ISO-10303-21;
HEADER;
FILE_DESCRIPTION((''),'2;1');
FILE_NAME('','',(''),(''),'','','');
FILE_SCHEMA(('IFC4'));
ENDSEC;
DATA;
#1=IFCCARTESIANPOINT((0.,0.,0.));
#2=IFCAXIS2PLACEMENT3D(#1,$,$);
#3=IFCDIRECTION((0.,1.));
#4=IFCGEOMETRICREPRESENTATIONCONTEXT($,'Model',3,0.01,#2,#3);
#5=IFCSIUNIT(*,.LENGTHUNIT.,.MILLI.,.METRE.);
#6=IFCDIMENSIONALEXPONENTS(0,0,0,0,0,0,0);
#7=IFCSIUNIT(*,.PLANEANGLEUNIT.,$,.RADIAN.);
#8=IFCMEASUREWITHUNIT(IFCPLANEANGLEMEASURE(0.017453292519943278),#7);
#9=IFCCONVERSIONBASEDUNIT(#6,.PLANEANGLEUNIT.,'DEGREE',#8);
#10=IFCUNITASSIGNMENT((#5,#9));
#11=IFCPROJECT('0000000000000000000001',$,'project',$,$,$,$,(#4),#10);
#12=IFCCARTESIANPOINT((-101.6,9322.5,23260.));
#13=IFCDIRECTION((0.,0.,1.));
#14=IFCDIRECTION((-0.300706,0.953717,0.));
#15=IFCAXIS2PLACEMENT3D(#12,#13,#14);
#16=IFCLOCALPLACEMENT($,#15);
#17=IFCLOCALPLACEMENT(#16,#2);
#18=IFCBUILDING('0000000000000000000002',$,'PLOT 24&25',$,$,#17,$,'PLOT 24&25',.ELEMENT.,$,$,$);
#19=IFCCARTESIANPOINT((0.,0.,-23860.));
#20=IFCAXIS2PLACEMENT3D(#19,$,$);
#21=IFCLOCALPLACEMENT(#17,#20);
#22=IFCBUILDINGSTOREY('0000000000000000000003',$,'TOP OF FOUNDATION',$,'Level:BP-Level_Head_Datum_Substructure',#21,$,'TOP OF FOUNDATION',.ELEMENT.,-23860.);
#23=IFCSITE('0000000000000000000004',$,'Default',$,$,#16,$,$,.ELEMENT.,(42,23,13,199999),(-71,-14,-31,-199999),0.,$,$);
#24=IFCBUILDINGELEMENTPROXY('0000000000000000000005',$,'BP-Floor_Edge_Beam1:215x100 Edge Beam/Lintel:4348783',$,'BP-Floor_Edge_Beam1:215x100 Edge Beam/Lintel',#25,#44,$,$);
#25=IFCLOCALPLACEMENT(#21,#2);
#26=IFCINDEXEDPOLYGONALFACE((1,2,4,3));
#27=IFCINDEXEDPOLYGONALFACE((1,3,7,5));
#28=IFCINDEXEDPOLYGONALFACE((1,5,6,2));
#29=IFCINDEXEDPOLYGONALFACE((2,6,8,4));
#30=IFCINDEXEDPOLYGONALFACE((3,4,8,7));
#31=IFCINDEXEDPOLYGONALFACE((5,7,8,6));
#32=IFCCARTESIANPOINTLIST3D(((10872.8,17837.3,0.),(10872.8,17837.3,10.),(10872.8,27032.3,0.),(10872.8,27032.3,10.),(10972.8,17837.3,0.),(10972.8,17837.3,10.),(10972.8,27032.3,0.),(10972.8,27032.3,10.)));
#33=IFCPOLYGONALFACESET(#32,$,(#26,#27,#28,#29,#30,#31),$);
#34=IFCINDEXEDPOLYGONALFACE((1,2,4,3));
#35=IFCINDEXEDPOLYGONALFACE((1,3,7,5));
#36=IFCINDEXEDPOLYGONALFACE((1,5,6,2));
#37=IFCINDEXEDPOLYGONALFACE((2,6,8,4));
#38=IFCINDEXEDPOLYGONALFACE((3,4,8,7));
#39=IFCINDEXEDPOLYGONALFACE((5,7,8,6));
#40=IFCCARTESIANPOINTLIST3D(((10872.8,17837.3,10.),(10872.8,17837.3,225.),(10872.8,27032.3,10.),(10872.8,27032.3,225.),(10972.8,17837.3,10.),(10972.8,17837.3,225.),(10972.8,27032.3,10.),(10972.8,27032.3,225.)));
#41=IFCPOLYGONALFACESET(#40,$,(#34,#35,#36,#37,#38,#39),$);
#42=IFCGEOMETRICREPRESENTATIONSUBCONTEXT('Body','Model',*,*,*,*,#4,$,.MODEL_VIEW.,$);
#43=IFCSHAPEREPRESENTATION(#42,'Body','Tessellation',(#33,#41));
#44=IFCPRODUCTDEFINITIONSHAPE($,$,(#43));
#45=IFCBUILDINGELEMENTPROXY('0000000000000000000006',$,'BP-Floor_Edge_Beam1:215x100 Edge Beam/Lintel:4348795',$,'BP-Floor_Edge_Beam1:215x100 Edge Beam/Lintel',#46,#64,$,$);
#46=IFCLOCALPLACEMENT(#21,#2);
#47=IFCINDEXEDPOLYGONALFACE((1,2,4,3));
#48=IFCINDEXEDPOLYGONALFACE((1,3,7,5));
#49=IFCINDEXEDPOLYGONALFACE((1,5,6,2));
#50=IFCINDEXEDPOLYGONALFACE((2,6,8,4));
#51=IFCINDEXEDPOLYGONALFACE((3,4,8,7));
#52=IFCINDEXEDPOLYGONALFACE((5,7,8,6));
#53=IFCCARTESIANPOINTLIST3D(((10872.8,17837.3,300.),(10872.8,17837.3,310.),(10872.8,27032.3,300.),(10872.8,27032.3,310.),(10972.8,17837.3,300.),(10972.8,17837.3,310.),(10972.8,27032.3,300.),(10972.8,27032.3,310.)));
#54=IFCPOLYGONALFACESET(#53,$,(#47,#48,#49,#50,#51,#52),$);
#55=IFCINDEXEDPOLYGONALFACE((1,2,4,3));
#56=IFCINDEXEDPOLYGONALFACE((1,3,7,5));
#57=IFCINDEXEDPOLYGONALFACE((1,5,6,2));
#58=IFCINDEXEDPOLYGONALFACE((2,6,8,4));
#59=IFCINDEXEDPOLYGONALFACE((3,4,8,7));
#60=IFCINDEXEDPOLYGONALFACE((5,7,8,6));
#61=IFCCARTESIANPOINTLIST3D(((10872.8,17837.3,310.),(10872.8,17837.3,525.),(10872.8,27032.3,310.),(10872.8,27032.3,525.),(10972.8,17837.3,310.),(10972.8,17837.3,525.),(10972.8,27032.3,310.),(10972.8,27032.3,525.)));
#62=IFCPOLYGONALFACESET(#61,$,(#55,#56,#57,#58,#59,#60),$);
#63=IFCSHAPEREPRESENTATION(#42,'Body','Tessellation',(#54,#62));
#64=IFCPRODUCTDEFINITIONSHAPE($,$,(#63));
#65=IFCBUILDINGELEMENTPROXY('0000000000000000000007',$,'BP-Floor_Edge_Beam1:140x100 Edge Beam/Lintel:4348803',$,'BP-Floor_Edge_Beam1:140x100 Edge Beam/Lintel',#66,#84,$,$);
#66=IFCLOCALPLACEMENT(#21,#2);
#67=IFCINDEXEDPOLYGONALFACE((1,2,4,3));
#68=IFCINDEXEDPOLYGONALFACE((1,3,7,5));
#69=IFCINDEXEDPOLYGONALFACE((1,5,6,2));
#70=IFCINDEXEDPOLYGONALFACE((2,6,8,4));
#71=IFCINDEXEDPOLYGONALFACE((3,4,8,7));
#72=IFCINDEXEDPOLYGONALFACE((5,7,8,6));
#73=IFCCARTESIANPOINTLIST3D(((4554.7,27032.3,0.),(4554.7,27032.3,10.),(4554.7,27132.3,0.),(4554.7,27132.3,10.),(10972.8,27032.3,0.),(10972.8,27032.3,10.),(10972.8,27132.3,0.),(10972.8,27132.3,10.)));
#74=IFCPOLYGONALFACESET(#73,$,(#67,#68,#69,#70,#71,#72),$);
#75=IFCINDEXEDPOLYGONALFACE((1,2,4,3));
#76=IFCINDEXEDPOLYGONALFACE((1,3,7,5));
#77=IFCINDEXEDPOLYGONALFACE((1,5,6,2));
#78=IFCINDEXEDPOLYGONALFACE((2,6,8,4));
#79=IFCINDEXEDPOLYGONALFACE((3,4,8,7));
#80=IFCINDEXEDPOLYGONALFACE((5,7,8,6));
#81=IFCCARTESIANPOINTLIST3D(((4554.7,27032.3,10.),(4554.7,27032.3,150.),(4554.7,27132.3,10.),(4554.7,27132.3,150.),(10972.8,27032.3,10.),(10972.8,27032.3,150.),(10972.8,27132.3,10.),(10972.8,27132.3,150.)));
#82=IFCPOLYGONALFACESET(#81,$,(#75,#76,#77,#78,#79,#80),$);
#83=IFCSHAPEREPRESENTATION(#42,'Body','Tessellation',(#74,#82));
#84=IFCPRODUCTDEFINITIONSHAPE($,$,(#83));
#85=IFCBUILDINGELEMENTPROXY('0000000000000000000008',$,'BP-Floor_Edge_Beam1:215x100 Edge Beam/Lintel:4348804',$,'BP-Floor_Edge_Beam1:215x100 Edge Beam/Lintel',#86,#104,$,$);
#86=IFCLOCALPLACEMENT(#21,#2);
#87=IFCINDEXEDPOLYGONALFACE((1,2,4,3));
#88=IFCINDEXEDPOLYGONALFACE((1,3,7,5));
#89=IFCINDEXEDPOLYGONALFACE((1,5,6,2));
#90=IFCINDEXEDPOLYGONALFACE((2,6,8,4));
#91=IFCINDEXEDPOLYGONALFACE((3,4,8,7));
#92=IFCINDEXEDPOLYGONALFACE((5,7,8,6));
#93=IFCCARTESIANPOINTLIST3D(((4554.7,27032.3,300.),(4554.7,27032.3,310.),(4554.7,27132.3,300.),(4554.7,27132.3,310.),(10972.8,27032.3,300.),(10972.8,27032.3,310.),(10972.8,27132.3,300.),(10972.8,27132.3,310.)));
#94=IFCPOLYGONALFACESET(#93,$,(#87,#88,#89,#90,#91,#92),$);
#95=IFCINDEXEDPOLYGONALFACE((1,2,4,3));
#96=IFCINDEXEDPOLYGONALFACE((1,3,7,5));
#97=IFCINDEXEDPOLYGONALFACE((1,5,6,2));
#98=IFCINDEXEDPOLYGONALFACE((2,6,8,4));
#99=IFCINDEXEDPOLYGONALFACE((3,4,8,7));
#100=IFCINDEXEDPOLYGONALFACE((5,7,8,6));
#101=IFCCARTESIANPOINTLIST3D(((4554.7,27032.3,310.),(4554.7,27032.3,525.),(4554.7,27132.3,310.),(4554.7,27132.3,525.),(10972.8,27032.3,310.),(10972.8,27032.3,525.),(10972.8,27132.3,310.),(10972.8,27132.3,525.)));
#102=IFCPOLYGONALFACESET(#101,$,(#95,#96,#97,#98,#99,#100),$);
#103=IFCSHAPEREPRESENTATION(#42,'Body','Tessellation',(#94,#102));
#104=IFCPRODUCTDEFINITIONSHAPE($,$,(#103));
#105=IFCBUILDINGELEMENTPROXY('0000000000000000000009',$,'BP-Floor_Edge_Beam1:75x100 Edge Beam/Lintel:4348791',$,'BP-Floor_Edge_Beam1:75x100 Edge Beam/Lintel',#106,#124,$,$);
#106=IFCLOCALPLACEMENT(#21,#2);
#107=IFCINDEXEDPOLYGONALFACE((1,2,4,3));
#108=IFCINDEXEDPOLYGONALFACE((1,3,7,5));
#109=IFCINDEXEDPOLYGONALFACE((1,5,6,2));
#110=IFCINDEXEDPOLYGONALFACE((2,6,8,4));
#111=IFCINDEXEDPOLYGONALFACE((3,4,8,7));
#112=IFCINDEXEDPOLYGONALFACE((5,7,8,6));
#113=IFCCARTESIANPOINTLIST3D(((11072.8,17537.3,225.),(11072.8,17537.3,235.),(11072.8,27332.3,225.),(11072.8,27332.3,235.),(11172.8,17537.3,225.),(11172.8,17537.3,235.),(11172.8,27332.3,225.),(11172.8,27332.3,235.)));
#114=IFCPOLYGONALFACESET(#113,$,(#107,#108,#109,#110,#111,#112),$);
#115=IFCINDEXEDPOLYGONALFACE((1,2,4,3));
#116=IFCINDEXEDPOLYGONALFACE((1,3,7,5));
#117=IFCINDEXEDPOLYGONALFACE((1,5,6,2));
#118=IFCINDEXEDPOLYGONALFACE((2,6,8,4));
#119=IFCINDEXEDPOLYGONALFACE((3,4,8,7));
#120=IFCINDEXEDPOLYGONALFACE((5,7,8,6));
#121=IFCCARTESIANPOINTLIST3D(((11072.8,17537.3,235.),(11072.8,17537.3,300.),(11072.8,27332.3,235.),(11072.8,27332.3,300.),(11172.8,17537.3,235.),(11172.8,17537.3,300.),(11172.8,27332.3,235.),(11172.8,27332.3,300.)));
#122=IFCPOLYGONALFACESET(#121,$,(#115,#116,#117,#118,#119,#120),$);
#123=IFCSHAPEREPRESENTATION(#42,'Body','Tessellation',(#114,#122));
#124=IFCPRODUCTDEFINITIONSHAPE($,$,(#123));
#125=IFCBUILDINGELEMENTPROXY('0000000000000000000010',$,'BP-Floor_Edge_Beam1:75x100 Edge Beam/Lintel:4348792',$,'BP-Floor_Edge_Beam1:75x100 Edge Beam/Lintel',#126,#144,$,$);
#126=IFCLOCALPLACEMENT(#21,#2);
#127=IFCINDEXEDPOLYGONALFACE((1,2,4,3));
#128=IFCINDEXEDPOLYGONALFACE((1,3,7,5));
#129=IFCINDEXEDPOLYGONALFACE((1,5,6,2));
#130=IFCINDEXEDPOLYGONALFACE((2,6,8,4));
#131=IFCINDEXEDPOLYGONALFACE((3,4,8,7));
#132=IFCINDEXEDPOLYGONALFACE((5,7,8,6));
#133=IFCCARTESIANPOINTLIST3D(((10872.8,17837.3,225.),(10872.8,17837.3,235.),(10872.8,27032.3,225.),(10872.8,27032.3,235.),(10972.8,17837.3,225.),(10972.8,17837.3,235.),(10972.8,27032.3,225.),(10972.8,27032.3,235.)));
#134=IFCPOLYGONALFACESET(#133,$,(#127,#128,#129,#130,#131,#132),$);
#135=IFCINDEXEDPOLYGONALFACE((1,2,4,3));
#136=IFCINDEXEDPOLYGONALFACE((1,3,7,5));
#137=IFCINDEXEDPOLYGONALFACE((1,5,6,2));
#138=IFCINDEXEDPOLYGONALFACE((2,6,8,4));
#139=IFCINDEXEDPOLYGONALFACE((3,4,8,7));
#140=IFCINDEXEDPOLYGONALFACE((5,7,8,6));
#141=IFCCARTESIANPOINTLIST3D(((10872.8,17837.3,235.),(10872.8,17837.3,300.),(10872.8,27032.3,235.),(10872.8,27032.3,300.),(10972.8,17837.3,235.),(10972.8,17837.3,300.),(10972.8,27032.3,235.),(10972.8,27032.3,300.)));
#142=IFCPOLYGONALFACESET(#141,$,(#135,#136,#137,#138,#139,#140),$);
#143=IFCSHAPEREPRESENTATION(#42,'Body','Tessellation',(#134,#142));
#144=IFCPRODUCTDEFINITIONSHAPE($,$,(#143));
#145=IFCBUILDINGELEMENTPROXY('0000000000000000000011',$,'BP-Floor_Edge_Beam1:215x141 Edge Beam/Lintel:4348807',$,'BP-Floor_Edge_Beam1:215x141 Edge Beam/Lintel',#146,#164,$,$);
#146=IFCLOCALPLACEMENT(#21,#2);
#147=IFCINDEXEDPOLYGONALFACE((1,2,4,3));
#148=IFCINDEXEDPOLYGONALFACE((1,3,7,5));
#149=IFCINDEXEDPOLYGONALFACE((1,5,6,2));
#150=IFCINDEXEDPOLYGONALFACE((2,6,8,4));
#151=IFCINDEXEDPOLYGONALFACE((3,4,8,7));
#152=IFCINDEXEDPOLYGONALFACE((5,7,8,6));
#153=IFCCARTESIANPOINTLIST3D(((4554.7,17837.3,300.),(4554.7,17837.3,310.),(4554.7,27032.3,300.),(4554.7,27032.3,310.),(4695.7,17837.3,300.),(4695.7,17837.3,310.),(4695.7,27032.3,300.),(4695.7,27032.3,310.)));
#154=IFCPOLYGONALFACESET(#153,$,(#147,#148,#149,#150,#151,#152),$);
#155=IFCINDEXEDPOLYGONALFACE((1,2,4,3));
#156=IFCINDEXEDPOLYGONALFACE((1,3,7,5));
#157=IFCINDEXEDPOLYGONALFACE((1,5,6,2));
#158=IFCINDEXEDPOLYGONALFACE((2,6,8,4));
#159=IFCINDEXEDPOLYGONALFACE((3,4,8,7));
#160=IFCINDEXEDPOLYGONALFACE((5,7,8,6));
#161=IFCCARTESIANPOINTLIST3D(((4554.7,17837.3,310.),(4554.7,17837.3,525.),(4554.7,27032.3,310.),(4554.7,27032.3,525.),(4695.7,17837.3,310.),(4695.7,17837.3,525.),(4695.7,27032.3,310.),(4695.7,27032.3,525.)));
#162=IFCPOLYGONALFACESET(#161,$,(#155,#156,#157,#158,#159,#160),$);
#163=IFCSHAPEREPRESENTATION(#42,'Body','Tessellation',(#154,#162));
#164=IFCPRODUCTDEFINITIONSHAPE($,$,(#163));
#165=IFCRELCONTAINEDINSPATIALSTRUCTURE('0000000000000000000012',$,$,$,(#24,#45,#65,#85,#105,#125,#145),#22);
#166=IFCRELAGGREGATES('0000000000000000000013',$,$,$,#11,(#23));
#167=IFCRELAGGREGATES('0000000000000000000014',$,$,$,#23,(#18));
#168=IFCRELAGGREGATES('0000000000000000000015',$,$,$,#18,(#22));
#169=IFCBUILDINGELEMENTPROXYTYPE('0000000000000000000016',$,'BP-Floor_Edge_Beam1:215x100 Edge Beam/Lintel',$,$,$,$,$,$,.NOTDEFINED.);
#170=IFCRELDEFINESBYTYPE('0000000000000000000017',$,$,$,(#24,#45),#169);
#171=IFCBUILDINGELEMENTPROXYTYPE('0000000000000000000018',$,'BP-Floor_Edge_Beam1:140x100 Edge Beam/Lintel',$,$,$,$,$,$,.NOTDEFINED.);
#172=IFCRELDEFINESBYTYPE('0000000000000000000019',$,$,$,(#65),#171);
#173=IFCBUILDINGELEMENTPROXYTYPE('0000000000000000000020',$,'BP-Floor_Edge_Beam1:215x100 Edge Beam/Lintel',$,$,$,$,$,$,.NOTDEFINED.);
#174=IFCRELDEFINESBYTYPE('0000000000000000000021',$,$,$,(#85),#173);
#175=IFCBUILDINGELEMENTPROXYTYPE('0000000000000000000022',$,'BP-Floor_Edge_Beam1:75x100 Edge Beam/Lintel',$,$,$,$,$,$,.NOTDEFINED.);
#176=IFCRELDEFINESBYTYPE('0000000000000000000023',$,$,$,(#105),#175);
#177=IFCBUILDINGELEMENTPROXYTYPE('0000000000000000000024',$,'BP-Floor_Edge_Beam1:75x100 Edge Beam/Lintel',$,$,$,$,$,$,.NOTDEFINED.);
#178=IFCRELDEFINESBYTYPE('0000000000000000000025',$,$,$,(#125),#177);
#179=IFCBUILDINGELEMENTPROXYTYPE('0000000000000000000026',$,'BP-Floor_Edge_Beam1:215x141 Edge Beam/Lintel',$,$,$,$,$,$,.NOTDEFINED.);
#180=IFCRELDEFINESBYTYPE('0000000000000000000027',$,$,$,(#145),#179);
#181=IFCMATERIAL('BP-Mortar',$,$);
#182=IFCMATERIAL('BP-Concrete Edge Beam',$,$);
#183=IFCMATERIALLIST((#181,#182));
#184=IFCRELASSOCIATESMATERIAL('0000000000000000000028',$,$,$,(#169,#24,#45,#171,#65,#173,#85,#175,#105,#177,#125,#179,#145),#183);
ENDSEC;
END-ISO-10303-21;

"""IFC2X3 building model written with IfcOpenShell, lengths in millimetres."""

from ifc_helpers import new_model, entity, si_unit, converted_unit, direction, frame, frame_2d, origin, origin_2d_with_axis, place, context, subcontext, project, spatial, rectangle, extrude, source, transform, mapped, material, material_list, type_object, type_shapes, element, save


model = new_model("IFC2X3")

# Units and contexts
model_context = context("Model", 3, precision=0.01, world=origin(), true_north=direction((0.0, 1.0)))
body_context = subcontext(model_context, "Body", "Model", "MODEL_VIEW")
ifc_project = project(units=[si_unit("LENGTHUNIT", "METRE", prefix="MILLI"), converted_unit("PLANEANGLEUNIT", "DEGREE", entity("IfcPlaneAngleMeasure", 0.017453292519943278), si_unit("PLANEANGLEUNIT", "RADIAN"), dimensions=[0, 0, 0, 0, 0, 0, 0])], contexts=[model_context])

# Site, building, storey
site_placement = place(None, frame((-101.6, 9322.5, 23260.0), z_axis=(0.0, 0.0, 1.0), x_axis=(-0.300706, 0.953717, 0.0)))
site = spatial("IfcSite", under=ifc_project, at=site_placement, Name="Default", CompositionType="ELEMENT", RefLatitude=(42, 23, 13, 199999), RefLongitude=(-71, -14, -31, -199999), RefElevation=0.0)
building_placement = place(site_placement, origin())
building = spatial("IfcBuilding", under=site, at=building_placement, Name="PLOT 24&25", LongName="PLOT 24&25", CompositionType="ELEMENT")
storey_placement = place(building_placement, frame((0.0, 0.0, -23860.0)))
storey = spatial("IfcBuildingStorey", under=building, at=storey_placement, Name="TOP OF FOUNDATION", ObjectType="Level:BP-Level_Head_Datum_Substructure", LongName="TOP OF FOUNDATION", CompositionType="ELEMENT", Elevation=-23860.0)

# Building element proxies
ifc_material_1 = material(Name="BP-Mortar")
ifc_material_2 = material(Name="BP-Concrete Edge Beam")
ifc_material_list = material_list([ifc_material_1, ifc_material_2])
building_element_proxy_type_1 = type_object("IfcBuildingElementProxyType", Name="BP-Floor_Edge_Beam1:215x100 Edge Beam/Lintel", PredefinedType="NOTDEFINED", material=ifc_material_list)
shared_shape_1 = source(origin(), body_context, "Body", "SweptSolid", [
    extrude(rectangle(XDim=100.0, YDim=9195.0, at=frame_2d((0.0, 0.0), x_axis=(1.0, 0.0))), frame((0.0, 0.0, 0.0), z_axis=(0.0, 0.0, 1.0), x_axis=(0.0, 1.0, 0.0)), (0.0, 0.0, 1.0), 10.0),
    extrude(rectangle(XDim=100.0, YDim=9195.0, at=origin_2d_with_axis()), frame((0.0, 0.0, 10.0), z_axis=(0.0, 0.0, 1.0), x_axis=(0.0, 1.0, 0.0)), (0.0, 0.0, 1.0), 215.0),
])
type_shapes(building_element_proxy_type_1, [shared_shape_1])
for number, where, z_axis, x_axis, name in (
    (1, (10922.8, 22434.8, 0.0), (0.0, 0.0, 1.0), (0.0, 1.0, 0.0), "BP-Floor_Edge_Beam1:215x100 Edge Beam/Lintel:4348783"),
    (2, (10922.8, 22434.8, 300.0), (0.0, 0.0, 1.0), (0.0, 1.0, 0.0), "BP-Floor_Edge_Beam1:215x100 Edge Beam/Lintel:4348795"),
):
    element("IfcBuildingElementProxy", number, at=place(storey_placement, frame(where, z_axis=z_axis, x_axis=x_axis)), inside=storey, type_object=building_element_proxy_type_1, material=ifc_material_list, Name=name, ObjectType="BP-Floor_Edge_Beam1:215x100 Edge Beam/Lintel", context=body_context, shape_type="MappedRepresentation", body=[
        mapped(shared_shape_1, transform((0.0, 0.0, 0.0), scale=1.0)),
    ])
building_element_proxy_type_2 = type_object("IfcBuildingElementProxyType", Name="BP-Floor_Edge_Beam1:140x100 Edge Beam/Lintel", PredefinedType="NOTDEFINED", material=ifc_material_list)
shared_shape_2 = source(origin(), body_context, "Body", "SweptSolid", [
    extrude(rectangle(XDim=6418.2, YDim=100.0, at=frame_2d((0.0, 0.0), x_axis=(1.0, 0.0))), frame((0.0, 0.0, 0.0), z_axis=(0.0, 0.0, 1.0), x_axis=(-1.0, 0.0, 0.0)), (0.0, 0.0, 1.0), 10.0),
    extrude(rectangle(XDim=6418.2, YDim=100.0, at=origin_2d_with_axis()), frame((0.0, 0.0, 10.0), z_axis=(0.0, 0.0, 1.0), x_axis=(-1.0, 0.0, 0.0)), (0.0, 0.0, 1.0), 140.0),
])
type_shapes(building_element_proxy_type_2, [shared_shape_2])
proxy_1_placement = place(storey_placement, frame((7763.8, 27082.3, 0.0), z_axis=(0.0, 0.0, 1.0), x_axis=(-1.0, 0.0, 0.0)))
element("IfcBuildingElementProxy", 3, at=proxy_1_placement, inside=storey, type_object=building_element_proxy_type_2, material=ifc_material_list, Name="BP-Floor_Edge_Beam1:140x100 Edge Beam/Lintel:4348803", ObjectType="BP-Floor_Edge_Beam1:140x100 Edge Beam/Lintel", context=body_context, shape_type="MappedRepresentation", body=[
    mapped(shared_shape_2, transform((0.0, 0.0, 0.0), scale=1.0)),
])
building_element_proxy_type_3 = type_object("IfcBuildingElementProxyType", Name="BP-Floor_Edge_Beam1:215x100 Edge Beam/Lintel", PredefinedType="NOTDEFINED", material=ifc_material_list)
shared_shape_3 = source(origin(), body_context, "Body", "SweptSolid", [
    extrude(rectangle(XDim=6418.2, YDim=100.0, at=frame_2d((0.0, 0.0), x_axis=(1.0, 0.0))), frame((0.0, 0.0, 0.0), z_axis=(0.0, 0.0, 1.0), x_axis=(-1.0, 0.0, 0.0)), (0.0, 0.0, 1.0), 10.0),
    extrude(rectangle(XDim=6418.2, YDim=100.0, at=origin_2d_with_axis()), frame((0.0, 0.0, 10.0), z_axis=(0.0, 0.0, 1.0), x_axis=(-1.0, 0.0, 0.0)), (0.0, 0.0, 1.0), 215.0),
])
type_shapes(building_element_proxy_type_3, [shared_shape_3])
proxy_2_placement = place(storey_placement, frame((7763.8, 27082.3, 300.0), z_axis=(0.0, 0.0, 1.0), x_axis=(-1.0, 0.0, 0.0)))
element("IfcBuildingElementProxy", 4, at=proxy_2_placement, inside=storey, type_object=building_element_proxy_type_3, material=ifc_material_list, Name="BP-Floor_Edge_Beam1:215x100 Edge Beam/Lintel:4348804", ObjectType="BP-Floor_Edge_Beam1:215x100 Edge Beam/Lintel", context=body_context, shape_type="MappedRepresentation", body=[
    mapped(shared_shape_3, transform((0.0, 0.0, 0.0), scale=1.0)),
])
building_element_proxy_type_4 = type_object("IfcBuildingElementProxyType", Name="BP-Floor_Edge_Beam1:75x100 Edge Beam/Lintel", PredefinedType="NOTDEFINED", material=ifc_material_list)
shared_shape_4 = source(origin(), body_context, "Body", "SweptSolid", [
    extrude(rectangle(XDim=100.0, YDim=9795.0, at=frame_2d((0.0, 0.0), x_axis=(1.0, 0.0))), frame((0.0, 0.0, 0.0), z_axis=(0.0, 0.0, 1.0), x_axis=(0.0, 1.0, 0.0)), (0.0, 0.0, 1.0), 10.0),
    extrude(rectangle(XDim=100.0, YDim=9795.0, at=origin_2d_with_axis()), frame((0.0, 0.0, 10.0), z_axis=(0.0, 0.0, 1.0), x_axis=(0.0, 1.0, 0.0)), (0.0, 0.0, 1.0), 65.0),
])
type_shapes(building_element_proxy_type_4, [shared_shape_4])
proxy_3_placement = place(storey_placement, frame((11122.8, 22434.8, 225.0), z_axis=(0.0, 0.0, 1.0), x_axis=(0.0, 1.0, 0.0)))
element("IfcBuildingElementProxy", 5, at=proxy_3_placement, inside=storey, type_object=building_element_proxy_type_4, material=ifc_material_list, Name="BP-Floor_Edge_Beam1:75x100 Edge Beam/Lintel:4348791", ObjectType="BP-Floor_Edge_Beam1:75x100 Edge Beam/Lintel", context=body_context, shape_type="MappedRepresentation", body=[
    mapped(shared_shape_4, transform((0.0, 0.0, 0.0), scale=1.0)),
])
building_element_proxy_type_5 = type_object("IfcBuildingElementProxyType", Name="BP-Floor_Edge_Beam1:75x100 Edge Beam/Lintel", PredefinedType="NOTDEFINED", material=ifc_material_list)
shared_shape_5 = source(origin(), body_context, "Body", "SweptSolid", [
    extrude(rectangle(XDim=100.0, YDim=9195.0, at=frame_2d((0.0, 0.0), x_axis=(1.0, 0.0))), frame((0.0, 0.0, 0.0), z_axis=(0.0, 0.0, 1.0), x_axis=(0.0, 1.0, 0.0)), (0.0, 0.0, 1.0), 10.0),
    extrude(rectangle(XDim=100.0, YDim=9195.0, at=origin_2d_with_axis()), frame((0.0, 0.0, 10.0), z_axis=(0.0, 0.0, 1.0), x_axis=(0.0, 1.0, 0.0)), (0.0, 0.0, 1.0), 65.0),
])
type_shapes(building_element_proxy_type_5, [shared_shape_5])
proxy_4_placement = place(storey_placement, frame((10922.8, 22434.8, 225.0), z_axis=(0.0, 0.0, 1.0), x_axis=(0.0, 1.0, 0.0)))
element("IfcBuildingElementProxy", 6, at=proxy_4_placement, inside=storey, type_object=building_element_proxy_type_5, material=ifc_material_list, Name="BP-Floor_Edge_Beam1:75x100 Edge Beam/Lintel:4348792", ObjectType="BP-Floor_Edge_Beam1:75x100 Edge Beam/Lintel", context=body_context, shape_type="MappedRepresentation", body=[
    mapped(shared_shape_5, transform((0.0, 0.0, 0.0), scale=1.0)),
])
building_element_proxy_type_6 = type_object("IfcBuildingElementProxyType", Name="BP-Floor_Edge_Beam1:215x141 Edge Beam/Lintel", PredefinedType="NOTDEFINED", material=ifc_material_list)
shared_shape_6 = source(origin(), body_context, "Body", "SweptSolid", [
    extrude(rectangle(XDim=141.0, YDim=9195.0, at=origin_2d_with_axis()), frame((0.0, 0.0, 0.0), z_axis=(0.0, 0.0, 1.0), x_axis=(0.0, 1.0, 0.0)), (0.0, 0.0, 1.0), 10.0),
    extrude(rectangle(XDim=141.0, YDim=9195.0, at=origin_2d_with_axis()), frame((0.0, 0.0, 10.0), z_axis=(0.0, 0.0, 1.0), x_axis=(0.0, 1.0, 0.0)), (0.0, 0.0, 1.0), 215.0),
])
type_shapes(building_element_proxy_type_6, [shared_shape_6])
proxy_5_placement = place(storey_placement, frame((4625.2, 22434.8, 300.0), z_axis=(0.0, 0.0, 1.0), x_axis=(0.0, 1.0, 0.0)))
element("IfcBuildingElementProxy", 7, at=proxy_5_placement, inside=storey, type_object=building_element_proxy_type_6, material=ifc_material_list, Name="BP-Floor_Edge_Beam1:215x141 Edge Beam/Lintel:4348807", ObjectType="BP-Floor_Edge_Beam1:215x141 Edge Beam/Lintel", context=body_context, shape_type="MappedRepresentation", body=[
    mapped(shared_shape_6, transform((0.0, 0.0, 0.0), scale=1.0)),
])

save(model, "model.ifc")
